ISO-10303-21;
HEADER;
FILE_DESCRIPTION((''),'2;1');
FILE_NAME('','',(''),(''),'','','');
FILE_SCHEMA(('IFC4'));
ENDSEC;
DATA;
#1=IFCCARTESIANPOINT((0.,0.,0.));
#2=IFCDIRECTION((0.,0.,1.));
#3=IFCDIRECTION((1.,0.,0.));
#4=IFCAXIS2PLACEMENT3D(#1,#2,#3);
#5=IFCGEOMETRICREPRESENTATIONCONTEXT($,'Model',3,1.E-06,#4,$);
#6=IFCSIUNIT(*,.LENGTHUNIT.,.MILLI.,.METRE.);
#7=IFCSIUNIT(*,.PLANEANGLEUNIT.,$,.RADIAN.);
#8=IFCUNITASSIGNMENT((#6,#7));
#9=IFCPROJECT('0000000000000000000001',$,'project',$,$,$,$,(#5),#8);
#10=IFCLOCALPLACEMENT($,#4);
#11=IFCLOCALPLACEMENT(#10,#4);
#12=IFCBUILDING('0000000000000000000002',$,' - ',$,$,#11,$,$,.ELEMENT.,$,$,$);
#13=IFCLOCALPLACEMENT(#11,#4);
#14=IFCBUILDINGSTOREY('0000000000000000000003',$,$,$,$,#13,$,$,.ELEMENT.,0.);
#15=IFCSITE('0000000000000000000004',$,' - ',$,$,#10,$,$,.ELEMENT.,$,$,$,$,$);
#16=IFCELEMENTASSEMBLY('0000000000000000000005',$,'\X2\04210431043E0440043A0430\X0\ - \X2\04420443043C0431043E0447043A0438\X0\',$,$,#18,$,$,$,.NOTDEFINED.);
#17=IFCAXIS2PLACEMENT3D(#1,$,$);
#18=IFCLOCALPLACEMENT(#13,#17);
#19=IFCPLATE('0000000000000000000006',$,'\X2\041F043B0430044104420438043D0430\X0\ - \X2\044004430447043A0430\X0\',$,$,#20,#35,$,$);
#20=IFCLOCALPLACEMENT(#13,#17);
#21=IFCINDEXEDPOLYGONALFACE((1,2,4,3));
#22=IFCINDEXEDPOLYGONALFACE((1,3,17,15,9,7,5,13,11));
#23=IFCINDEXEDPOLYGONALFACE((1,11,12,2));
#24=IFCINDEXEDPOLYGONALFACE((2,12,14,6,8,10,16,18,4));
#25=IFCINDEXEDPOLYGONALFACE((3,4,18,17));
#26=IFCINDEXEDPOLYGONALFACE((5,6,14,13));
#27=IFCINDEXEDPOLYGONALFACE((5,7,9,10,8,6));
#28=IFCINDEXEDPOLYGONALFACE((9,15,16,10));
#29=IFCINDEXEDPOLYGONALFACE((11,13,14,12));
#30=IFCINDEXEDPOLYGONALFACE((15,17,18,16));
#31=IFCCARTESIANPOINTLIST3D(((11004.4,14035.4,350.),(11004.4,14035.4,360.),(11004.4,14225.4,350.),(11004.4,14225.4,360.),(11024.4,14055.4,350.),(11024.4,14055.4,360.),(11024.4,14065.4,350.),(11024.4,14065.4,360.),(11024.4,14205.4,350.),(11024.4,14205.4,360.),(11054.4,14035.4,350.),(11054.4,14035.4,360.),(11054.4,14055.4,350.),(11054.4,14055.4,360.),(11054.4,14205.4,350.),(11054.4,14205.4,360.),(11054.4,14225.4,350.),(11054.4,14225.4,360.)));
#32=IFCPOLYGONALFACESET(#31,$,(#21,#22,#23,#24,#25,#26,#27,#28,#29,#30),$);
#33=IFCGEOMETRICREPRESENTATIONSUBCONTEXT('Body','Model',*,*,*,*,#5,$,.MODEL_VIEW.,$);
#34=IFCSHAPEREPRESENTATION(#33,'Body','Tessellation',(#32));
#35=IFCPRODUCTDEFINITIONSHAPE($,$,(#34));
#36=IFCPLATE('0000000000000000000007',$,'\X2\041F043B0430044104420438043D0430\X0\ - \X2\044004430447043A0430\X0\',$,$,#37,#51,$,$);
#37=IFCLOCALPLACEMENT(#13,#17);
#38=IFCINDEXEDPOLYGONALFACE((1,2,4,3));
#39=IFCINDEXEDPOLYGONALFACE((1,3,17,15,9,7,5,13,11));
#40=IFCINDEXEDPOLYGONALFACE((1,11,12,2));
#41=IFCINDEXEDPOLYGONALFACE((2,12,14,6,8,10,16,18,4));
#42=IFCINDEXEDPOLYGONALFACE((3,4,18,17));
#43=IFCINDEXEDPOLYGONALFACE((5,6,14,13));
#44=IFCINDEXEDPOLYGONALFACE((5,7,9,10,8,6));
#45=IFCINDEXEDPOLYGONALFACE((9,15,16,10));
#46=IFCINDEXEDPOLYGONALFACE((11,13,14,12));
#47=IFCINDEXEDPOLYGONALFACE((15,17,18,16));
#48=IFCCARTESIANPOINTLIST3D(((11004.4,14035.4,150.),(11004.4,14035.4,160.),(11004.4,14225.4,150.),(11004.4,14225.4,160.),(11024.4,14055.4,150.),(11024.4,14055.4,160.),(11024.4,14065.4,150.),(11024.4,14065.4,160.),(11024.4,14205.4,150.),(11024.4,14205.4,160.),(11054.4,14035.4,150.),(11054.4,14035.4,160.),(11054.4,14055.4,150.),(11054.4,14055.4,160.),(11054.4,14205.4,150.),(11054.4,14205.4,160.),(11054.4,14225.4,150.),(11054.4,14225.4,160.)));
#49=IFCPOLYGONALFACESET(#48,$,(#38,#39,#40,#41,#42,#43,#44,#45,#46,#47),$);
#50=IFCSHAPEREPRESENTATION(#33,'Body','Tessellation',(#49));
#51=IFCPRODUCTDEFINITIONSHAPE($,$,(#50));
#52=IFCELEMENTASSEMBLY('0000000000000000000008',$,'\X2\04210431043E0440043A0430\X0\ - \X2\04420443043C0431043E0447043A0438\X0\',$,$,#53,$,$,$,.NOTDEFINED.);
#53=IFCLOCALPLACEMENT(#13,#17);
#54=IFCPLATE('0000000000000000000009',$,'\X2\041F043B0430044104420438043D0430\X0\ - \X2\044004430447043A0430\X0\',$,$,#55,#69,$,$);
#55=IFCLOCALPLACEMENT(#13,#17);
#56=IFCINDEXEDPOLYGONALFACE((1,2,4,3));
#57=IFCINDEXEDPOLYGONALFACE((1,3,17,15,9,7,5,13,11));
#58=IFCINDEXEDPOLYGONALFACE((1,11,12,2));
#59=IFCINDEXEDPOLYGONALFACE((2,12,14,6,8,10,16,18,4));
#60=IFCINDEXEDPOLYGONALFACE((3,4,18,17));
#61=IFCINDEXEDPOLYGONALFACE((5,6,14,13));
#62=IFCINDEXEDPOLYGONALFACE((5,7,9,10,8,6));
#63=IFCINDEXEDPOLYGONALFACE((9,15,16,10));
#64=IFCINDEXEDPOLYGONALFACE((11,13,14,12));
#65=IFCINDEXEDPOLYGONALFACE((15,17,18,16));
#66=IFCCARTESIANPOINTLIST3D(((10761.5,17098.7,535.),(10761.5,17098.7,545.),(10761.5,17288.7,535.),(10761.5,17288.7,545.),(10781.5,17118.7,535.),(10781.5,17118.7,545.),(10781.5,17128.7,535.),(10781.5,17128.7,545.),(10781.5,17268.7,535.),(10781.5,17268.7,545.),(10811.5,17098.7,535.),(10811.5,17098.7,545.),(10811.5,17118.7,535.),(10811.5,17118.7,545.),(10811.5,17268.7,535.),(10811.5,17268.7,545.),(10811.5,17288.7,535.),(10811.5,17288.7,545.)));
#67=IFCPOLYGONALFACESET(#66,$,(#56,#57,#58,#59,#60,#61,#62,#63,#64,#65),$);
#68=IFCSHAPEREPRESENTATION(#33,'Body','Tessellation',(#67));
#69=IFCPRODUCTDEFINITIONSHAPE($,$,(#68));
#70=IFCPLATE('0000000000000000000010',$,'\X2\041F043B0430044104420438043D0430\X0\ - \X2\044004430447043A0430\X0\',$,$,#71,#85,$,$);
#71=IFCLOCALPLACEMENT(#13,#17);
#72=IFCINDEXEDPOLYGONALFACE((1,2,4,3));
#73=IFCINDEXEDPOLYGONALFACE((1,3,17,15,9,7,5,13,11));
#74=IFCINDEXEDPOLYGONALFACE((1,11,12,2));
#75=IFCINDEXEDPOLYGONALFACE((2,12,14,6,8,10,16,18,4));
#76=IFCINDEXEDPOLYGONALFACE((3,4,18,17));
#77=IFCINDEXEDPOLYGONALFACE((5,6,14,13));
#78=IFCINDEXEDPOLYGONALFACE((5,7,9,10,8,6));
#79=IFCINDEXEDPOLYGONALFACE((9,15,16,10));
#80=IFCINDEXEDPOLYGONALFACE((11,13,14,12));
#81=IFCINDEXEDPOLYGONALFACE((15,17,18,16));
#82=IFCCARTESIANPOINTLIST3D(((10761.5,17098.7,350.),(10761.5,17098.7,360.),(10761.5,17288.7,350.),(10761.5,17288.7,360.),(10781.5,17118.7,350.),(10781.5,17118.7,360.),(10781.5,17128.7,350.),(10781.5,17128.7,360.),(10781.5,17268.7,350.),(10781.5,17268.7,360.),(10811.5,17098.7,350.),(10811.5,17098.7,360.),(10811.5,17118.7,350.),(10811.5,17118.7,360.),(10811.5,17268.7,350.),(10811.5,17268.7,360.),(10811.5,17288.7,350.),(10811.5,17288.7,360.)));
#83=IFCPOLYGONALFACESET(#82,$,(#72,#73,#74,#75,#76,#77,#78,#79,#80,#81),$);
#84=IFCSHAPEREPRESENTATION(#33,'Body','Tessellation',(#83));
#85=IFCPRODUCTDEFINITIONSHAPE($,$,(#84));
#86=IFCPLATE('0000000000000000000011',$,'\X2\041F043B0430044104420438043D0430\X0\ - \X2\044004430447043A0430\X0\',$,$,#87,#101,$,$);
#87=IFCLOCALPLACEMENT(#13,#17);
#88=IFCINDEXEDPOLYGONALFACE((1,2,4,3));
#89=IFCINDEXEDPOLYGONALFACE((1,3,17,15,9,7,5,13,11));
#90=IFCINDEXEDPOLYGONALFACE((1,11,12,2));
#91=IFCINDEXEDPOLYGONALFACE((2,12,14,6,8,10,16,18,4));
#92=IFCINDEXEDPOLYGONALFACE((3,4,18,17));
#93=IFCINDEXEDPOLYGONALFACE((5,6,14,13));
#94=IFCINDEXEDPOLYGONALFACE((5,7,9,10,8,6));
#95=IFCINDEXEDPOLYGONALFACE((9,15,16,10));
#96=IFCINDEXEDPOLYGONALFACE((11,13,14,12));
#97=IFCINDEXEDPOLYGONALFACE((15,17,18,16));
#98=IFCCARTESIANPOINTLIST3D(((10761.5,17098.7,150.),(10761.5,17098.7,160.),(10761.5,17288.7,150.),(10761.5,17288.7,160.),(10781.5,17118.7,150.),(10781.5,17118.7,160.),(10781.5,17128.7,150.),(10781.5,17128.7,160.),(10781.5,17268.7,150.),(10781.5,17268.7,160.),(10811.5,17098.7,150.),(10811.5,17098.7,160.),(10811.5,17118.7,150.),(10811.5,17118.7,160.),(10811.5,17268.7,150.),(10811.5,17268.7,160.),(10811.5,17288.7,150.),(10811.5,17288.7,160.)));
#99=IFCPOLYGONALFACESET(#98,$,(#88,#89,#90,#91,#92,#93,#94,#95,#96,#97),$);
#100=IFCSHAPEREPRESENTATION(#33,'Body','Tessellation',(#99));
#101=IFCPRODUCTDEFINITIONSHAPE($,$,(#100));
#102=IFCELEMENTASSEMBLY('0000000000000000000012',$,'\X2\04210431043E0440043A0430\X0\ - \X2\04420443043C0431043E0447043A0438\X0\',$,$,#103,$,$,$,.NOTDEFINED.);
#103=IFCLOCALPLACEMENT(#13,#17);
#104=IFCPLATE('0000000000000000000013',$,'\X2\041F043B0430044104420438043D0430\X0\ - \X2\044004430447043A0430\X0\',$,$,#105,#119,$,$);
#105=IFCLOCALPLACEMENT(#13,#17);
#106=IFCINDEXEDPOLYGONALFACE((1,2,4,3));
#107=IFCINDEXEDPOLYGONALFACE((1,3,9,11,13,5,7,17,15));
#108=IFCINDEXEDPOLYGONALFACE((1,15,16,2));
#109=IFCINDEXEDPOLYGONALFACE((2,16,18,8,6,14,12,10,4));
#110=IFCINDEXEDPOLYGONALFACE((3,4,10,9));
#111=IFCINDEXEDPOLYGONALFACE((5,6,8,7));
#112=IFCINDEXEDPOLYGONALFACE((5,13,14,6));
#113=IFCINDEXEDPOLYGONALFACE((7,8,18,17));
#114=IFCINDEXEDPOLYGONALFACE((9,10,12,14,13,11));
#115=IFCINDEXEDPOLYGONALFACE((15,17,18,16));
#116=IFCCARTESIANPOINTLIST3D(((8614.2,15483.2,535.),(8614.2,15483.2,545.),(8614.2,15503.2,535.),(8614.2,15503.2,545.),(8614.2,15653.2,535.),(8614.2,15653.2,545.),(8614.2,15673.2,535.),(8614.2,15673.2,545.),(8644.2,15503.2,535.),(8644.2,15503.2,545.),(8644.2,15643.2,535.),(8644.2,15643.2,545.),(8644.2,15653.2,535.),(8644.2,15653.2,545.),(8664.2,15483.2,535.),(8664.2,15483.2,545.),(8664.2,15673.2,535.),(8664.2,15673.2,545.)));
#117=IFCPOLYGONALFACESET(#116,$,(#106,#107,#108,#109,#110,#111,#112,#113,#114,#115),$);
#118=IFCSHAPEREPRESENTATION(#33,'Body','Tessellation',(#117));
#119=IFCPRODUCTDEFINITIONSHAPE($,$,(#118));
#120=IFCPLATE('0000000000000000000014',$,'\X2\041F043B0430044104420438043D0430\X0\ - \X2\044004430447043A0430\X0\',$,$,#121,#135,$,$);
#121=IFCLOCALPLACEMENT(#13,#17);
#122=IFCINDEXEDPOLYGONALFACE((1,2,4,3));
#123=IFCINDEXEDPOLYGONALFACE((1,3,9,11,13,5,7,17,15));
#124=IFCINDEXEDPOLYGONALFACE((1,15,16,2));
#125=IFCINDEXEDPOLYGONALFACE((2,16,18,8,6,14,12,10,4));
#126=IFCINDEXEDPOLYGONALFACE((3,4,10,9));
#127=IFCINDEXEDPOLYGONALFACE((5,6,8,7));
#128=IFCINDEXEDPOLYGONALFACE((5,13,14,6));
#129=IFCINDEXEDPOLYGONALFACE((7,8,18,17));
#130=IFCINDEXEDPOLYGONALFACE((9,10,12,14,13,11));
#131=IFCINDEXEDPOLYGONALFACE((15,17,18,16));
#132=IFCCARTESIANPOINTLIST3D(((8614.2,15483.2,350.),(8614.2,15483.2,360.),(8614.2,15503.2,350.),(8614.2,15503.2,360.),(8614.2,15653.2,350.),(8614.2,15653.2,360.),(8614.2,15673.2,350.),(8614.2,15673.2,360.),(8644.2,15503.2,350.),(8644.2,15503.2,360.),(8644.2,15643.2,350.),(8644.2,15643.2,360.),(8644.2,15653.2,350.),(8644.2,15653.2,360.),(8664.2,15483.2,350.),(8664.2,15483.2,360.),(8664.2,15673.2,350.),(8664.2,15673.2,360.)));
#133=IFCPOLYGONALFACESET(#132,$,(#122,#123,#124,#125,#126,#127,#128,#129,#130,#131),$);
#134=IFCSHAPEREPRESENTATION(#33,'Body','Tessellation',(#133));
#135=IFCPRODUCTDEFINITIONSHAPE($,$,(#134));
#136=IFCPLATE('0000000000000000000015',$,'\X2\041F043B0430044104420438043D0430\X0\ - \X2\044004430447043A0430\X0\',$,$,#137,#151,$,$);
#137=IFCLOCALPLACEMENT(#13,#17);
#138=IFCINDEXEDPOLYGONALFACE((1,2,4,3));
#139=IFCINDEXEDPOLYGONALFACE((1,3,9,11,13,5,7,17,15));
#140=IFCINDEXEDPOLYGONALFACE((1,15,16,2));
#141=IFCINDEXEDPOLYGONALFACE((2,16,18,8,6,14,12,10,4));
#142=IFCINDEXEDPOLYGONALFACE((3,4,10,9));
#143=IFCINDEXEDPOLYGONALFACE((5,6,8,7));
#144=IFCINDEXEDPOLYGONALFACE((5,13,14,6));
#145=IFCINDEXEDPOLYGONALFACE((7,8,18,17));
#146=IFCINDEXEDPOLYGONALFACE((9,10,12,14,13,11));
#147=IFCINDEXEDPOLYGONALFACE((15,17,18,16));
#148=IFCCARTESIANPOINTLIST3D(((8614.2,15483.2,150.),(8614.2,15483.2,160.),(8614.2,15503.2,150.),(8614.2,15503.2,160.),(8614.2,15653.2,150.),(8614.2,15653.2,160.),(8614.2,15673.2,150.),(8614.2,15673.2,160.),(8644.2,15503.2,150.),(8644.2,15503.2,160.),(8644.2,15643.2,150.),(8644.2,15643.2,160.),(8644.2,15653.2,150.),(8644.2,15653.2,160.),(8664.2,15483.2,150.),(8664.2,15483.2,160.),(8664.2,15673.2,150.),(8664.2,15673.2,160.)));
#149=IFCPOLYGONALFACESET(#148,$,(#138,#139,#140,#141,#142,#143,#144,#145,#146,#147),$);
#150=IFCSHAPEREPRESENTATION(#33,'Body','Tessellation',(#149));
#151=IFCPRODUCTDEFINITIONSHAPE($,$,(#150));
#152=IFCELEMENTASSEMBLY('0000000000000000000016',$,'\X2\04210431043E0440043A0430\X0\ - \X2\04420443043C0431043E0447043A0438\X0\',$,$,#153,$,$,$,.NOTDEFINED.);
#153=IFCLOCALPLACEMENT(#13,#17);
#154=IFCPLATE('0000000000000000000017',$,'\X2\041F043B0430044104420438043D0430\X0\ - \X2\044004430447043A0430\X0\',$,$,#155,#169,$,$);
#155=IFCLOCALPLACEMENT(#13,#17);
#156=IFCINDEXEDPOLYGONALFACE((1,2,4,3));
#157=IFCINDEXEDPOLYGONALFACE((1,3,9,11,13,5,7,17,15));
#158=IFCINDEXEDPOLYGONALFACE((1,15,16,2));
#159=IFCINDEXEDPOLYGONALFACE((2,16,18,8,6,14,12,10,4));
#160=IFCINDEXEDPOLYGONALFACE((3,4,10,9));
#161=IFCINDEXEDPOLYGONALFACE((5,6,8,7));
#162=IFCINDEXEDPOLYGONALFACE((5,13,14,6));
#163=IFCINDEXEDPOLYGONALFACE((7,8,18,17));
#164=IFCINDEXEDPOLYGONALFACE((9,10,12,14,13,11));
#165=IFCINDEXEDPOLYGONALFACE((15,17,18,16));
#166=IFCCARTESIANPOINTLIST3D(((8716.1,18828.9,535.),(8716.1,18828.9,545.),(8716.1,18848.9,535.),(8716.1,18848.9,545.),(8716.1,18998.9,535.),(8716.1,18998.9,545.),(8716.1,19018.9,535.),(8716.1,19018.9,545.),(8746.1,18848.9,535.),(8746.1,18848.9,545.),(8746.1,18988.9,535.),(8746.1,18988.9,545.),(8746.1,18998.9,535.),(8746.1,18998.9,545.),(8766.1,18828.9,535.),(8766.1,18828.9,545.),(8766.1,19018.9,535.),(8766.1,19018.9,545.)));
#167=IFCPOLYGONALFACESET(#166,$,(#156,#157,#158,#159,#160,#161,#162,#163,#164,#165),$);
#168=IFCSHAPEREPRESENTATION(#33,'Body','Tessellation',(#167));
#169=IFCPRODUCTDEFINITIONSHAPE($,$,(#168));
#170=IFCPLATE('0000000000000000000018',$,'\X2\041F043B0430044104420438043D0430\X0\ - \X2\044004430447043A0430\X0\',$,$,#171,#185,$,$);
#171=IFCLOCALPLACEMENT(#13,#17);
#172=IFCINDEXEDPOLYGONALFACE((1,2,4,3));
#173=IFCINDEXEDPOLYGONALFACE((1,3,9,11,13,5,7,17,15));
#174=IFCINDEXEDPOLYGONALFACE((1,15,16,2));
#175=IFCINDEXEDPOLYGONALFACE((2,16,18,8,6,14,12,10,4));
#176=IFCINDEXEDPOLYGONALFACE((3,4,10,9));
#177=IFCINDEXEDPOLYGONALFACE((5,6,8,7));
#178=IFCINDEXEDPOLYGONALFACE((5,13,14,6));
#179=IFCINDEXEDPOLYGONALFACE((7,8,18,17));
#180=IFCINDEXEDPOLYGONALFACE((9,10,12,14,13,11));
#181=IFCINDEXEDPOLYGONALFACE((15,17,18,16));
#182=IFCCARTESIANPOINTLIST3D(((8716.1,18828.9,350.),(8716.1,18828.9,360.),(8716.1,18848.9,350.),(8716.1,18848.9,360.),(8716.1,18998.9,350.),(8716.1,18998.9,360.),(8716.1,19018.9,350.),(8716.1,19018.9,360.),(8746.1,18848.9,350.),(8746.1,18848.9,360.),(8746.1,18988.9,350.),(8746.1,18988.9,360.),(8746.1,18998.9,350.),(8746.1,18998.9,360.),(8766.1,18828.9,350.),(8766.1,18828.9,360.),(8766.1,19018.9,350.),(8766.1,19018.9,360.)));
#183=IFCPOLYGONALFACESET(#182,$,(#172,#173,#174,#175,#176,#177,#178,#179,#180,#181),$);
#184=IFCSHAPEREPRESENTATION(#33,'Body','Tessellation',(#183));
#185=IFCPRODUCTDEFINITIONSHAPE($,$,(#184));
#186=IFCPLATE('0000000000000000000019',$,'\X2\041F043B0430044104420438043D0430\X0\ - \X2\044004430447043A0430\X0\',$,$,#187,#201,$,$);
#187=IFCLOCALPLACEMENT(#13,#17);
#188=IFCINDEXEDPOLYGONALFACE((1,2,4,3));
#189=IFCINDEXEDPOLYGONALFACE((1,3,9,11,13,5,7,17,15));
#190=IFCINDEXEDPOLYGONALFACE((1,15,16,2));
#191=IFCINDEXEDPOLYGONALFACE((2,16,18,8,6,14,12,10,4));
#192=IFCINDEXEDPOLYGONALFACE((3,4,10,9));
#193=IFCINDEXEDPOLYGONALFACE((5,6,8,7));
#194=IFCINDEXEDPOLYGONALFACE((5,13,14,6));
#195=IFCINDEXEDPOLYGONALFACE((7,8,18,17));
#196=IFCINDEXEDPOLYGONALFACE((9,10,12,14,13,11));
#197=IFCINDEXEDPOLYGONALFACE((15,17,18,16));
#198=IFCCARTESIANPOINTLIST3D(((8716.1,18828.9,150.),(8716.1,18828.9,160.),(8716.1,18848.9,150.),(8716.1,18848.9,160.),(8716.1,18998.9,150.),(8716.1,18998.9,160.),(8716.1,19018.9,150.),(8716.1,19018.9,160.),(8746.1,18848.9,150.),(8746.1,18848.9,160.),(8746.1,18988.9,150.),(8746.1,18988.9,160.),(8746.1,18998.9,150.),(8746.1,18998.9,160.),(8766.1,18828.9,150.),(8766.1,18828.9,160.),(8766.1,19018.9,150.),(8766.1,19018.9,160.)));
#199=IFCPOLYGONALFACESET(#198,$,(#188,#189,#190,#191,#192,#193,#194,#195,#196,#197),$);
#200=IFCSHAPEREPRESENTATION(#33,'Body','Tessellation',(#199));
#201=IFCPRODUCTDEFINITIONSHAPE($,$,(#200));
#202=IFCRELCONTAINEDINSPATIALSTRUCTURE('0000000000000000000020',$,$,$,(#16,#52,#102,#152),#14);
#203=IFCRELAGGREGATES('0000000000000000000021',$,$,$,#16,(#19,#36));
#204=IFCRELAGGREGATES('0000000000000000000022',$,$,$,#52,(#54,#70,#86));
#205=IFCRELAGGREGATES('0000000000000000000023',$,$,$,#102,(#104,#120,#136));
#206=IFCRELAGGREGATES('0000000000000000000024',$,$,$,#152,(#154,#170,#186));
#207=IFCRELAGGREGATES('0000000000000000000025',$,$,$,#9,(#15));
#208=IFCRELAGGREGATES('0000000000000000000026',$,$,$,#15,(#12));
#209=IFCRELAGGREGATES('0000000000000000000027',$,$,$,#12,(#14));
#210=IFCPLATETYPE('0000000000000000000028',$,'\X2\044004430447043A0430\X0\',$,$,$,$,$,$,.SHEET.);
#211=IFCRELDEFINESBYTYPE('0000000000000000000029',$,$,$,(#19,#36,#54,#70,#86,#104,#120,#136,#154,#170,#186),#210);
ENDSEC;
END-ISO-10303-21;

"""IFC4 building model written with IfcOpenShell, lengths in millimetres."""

from ifc_helpers import new_model, si_unit, frame, origin_with_axes, place, context, subcontext, project, spatial, line, indexed_curve, outline, extrude, source, transform, mapped, type_object, element, aggregate, save


model = new_model("IFC4")

# Units and contexts
model_context = context("Model", 3, precision=1e-06, world=origin_with_axes())
body_context = subcontext(model_context, "Body", "Model", "MODEL_VIEW")
ifc_project = project(units=[si_unit("LENGTHUNIT", "METRE", prefix="MILLI"), si_unit("PLANEANGLEUNIT", "RADIAN")], contexts=[model_context])

# Site, building, storey
site_placement = place(None, origin_with_axes())
site = spatial("IfcSite", under=ifc_project, at=site_placement, Name=" - ", CompositionType="ELEMENT")
building_placement = place(site_placement, origin_with_axes())
building = spatial("IfcBuilding", under=site, at=building_placement, Name=" - ", CompositionType="ELEMENT")
storey_placement = place(building_placement, origin_with_axes())
storey = spatial("IfcBuildingStorey", under=building, at=storey_placement, CompositionType="ELEMENT", Elevation=0.0)

# Element assemblies, plates
assembly_1_placement = place(storey_placement, frame((11054.4, 14330.4, 0.0), z_axis=(0.0, 0.0, 1.0), x_axis=(0.0, -1.0, 0.0)))
assembly_1 = element("IfcElementAssembly", 1, at=assembly_1_placement, inside=storey, Name="Сборка - тумбочки", PredefinedType="NOTDEFINED")
plate_type = type_object("IfcPlateType", Name="ручка", PredefinedType="SHEET")
shared_shape = source(origin_with_axes(), body_context, "Body", "SweptSolid", [
    extrude(outline(indexed_curve([(-95.0, -25.0), (-75.0, -25.0), (-75.0, 5.0), (-65.0, 5.0), (75.0, 5.0), (75.0, -25.0), (95.0, -25.0), (95.0, 25.0), (-95.0, 25.0)], segments=[line(1, 2), line(2, 3), line(3, 4), line(4, 5), line(5, 6), line(6, 7), line(7, 8), line(8, 9), line(9, 1)])), origin_with_axes(), (0.0, 0.0, 1.0), 10.0),
])
plate_1_placement = place(assembly_1_placement, frame((200.0, -25.0, 350.0), z_axis=(0.0, 0.0, 1.0), x_axis=(-1.0, 0.0, 0.0)))
plate_1 = element("IfcPlate", 2, at=plate_1_placement, type_object=plate_type, Name="Пластина - ручка", context=body_context, shape_type="MappedRepresentation", body=[
    mapped(shared_shape, transform((0.0, 0.0, 0.0), x_axis=(1.0, 0.0, 0.0), y_axis=(0.0, 1.0, 0.0), z_axis=(0.0, 0.0, 1.0), scale=1.0)),
])
plate_2_placement = place(assembly_1_placement, frame((200.0, -25.0, 150.0), z_axis=(0.0, 0.0, 1.0), x_axis=(-1.0, 0.0, 0.0)))
plate_2 = element("IfcPlate", 3, at=plate_2_placement, type_object=plate_type, Name="Пластина - ручка", context=body_context, shape_type="MappedRepresentation", body=[
    mapped(shared_shape, transform((0.0, 0.0, 0.0), x_axis=(1.0, 0.0, 0.0), y_axis=(0.0, 1.0, 0.0), z_axis=(0.0, 0.0, 1.0), scale=1.0)),
])
aggregate(assembly_1, [plate_1, plate_2])
assembly_2_placement = place(storey_placement, frame((10811.5, 17393.7, 0.0), z_axis=(0.0, 0.0, 1.0), x_axis=(0.0, -1.0, 0.0)))
assembly_2 = element("IfcElementAssembly", 4, at=assembly_2_placement, inside=storey, Name="Сборка - тумбочки", PredefinedType="NOTDEFINED")
plate_3_placement = place(assembly_2_placement, frame((200.0, -25.0, 535.0), z_axis=(0.0, 0.0, 1.0), x_axis=(-1.0, 0.0, 0.0)))
plate_3 = element("IfcPlate", 5, at=plate_3_placement, type_object=plate_type, Name="Пластина - ручка", context=body_context, shape_type="MappedRepresentation", body=[
    mapped(shared_shape, transform((0.0, 0.0, 0.0), x_axis=(1.0, 0.0, 0.0), y_axis=(0.0, 1.0, 0.0), z_axis=(0.0, 0.0, 1.0), scale=1.0)),
])
plate_4_placement = place(assembly_2_placement, frame((200.0, -25.0, 350.0), z_axis=(0.0, 0.0, 1.0), x_axis=(-1.0, 0.0, 0.0)))
plate_4 = element("IfcPlate", 6, at=plate_4_placement, type_object=plate_type, Name="Пластина - ручка", context=body_context, shape_type="MappedRepresentation", body=[
    mapped(shared_shape, transform((0.0, 0.0, 0.0), x_axis=(1.0, 0.0, 0.0), y_axis=(0.0, 1.0, 0.0), z_axis=(0.0, 0.0, 1.0), scale=1.0)),
])
plate_5_placement = place(assembly_2_placement, frame((200.0, -25.0, 150.0), z_axis=(0.0, 0.0, 1.0), x_axis=(-1.0, 0.0, 0.0)))
plate_5 = element("IfcPlate", 7, at=plate_5_placement, type_object=plate_type, Name="Пластина - ручка", context=body_context, shape_type="MappedRepresentation", body=[
    mapped(shared_shape, transform((0.0, 0.0, 0.0), x_axis=(1.0, 0.0, 0.0), y_axis=(0.0, 1.0, 0.0), z_axis=(0.0, 0.0, 1.0), scale=1.0)),
])
aggregate(assembly_2, [plate_3, plate_4, plate_5])
assembly_3_placement = place(storey_placement, frame((8614.2, 15378.2, 0.0), z_axis=(0.0, 0.0, 1.0), x_axis=(0.0, 1.0, 0.0)))
assembly_3 = element("IfcElementAssembly", 8, at=assembly_3_placement, inside=storey, Name="Сборка - тумбочки", PredefinedType="NOTDEFINED")
plate_6_placement = place(assembly_3_placement, frame((200.0, -25.0, 535.0), z_axis=(0.0, 0.0, 1.0), x_axis=(-1.0, 0.0, 0.0)))
plate_6 = element("IfcPlate", 9, at=plate_6_placement, type_object=plate_type, Name="Пластина - ручка", context=body_context, shape_type="MappedRepresentation", body=[
    mapped(shared_shape, transform((0.0, 0.0, 0.0), x_axis=(1.0, 0.0, 0.0), y_axis=(0.0, 1.0, 0.0), z_axis=(0.0, 0.0, 1.0), scale=1.0)),
])
plate_7_placement = place(assembly_3_placement, frame((200.0, -25.0, 350.0), z_axis=(0.0, 0.0, 1.0), x_axis=(-1.0, 0.0, 0.0)))
plate_7 = element("IfcPlate", 10, at=plate_7_placement, type_object=plate_type, Name="Пластина - ручка", context=body_context, shape_type="MappedRepresentation", body=[
    mapped(shared_shape, transform((0.0, 0.0, 0.0), x_axis=(1.0, 0.0, 0.0), y_axis=(0.0, 1.0, 0.0), z_axis=(0.0, 0.0, 1.0), scale=1.0)),
])
plate_8_placement = place(assembly_3_placement, frame((200.0, -25.0, 150.0), z_axis=(0.0, 0.0, 1.0), x_axis=(-1.0, 0.0, 0.0)))
plate_8 = element("IfcPlate", 11, at=plate_8_placement, type_object=plate_type, Name="Пластина - ручка", context=body_context, shape_type="MappedRepresentation", body=[
    mapped(shared_shape, transform((0.0, 0.0, 0.0), x_axis=(1.0, 0.0, 0.0), y_axis=(0.0, 1.0, 0.0), z_axis=(0.0, 0.0, 1.0), scale=1.0)),
])
aggregate(assembly_3, [plate_6, plate_7, plate_8])
assembly_4_placement = place(storey_placement, frame((8716.1, 18723.9, 0.0), z_axis=(0.0, 0.0, 1.0), x_axis=(0.0, 1.0, 0.0)))
assembly_4 = element("IfcElementAssembly", 12, at=assembly_4_placement, inside=storey, Name="Сборка - тумбочки", PredefinedType="NOTDEFINED")
plate_9_placement = place(assembly_4_placement, frame((200.0, -25.0, 535.0), z_axis=(0.0, 0.0, 1.0), x_axis=(-1.0, 0.0, 0.0)))
plate_9 = element("IfcPlate", 13, at=plate_9_placement, type_object=plate_type, Name="Пластина - ручка", context=body_context, shape_type="MappedRepresentation", body=[
    mapped(shared_shape, transform((0.0, 0.0, 0.0), x_axis=(1.0, 0.0, 0.0), y_axis=(0.0, 1.0, 0.0), z_axis=(0.0, 0.0, 1.0), scale=1.0)),
])
plate_10_placement = place(assembly_4_placement, frame((200.0, -25.0, 350.0), z_axis=(0.0, 0.0, 1.0), x_axis=(-1.0, 0.0, 0.0)))
plate_10 = element("IfcPlate", 14, at=plate_10_placement, type_object=plate_type, Name="Пластина - ручка", context=body_context, shape_type="MappedRepresentation", body=[
    mapped(shared_shape, transform((0.0, 0.0, 0.0), x_axis=(1.0, 0.0, 0.0), y_axis=(0.0, 1.0, 0.0), z_axis=(0.0, 0.0, 1.0), scale=1.0)),
])
plate_11_placement = place(assembly_4_placement, frame((200.0, -25.0, 150.0), z_axis=(0.0, 0.0, 1.0), x_axis=(-1.0, 0.0, 0.0)))
plate_11 = element("IfcPlate", 15, at=plate_11_placement, type_object=plate_type, Name="Пластина - ручка", context=body_context, shape_type="MappedRepresentation", body=[
    mapped(shared_shape, transform((0.0, 0.0, 0.0), x_axis=(1.0, 0.0, 0.0), y_axis=(0.0, 1.0, 0.0), z_axis=(0.0, 0.0, 1.0), scale=1.0)),
])
aggregate(assembly_4, [plate_9, plate_10, plate_11])

save(model, "model.ifc")
